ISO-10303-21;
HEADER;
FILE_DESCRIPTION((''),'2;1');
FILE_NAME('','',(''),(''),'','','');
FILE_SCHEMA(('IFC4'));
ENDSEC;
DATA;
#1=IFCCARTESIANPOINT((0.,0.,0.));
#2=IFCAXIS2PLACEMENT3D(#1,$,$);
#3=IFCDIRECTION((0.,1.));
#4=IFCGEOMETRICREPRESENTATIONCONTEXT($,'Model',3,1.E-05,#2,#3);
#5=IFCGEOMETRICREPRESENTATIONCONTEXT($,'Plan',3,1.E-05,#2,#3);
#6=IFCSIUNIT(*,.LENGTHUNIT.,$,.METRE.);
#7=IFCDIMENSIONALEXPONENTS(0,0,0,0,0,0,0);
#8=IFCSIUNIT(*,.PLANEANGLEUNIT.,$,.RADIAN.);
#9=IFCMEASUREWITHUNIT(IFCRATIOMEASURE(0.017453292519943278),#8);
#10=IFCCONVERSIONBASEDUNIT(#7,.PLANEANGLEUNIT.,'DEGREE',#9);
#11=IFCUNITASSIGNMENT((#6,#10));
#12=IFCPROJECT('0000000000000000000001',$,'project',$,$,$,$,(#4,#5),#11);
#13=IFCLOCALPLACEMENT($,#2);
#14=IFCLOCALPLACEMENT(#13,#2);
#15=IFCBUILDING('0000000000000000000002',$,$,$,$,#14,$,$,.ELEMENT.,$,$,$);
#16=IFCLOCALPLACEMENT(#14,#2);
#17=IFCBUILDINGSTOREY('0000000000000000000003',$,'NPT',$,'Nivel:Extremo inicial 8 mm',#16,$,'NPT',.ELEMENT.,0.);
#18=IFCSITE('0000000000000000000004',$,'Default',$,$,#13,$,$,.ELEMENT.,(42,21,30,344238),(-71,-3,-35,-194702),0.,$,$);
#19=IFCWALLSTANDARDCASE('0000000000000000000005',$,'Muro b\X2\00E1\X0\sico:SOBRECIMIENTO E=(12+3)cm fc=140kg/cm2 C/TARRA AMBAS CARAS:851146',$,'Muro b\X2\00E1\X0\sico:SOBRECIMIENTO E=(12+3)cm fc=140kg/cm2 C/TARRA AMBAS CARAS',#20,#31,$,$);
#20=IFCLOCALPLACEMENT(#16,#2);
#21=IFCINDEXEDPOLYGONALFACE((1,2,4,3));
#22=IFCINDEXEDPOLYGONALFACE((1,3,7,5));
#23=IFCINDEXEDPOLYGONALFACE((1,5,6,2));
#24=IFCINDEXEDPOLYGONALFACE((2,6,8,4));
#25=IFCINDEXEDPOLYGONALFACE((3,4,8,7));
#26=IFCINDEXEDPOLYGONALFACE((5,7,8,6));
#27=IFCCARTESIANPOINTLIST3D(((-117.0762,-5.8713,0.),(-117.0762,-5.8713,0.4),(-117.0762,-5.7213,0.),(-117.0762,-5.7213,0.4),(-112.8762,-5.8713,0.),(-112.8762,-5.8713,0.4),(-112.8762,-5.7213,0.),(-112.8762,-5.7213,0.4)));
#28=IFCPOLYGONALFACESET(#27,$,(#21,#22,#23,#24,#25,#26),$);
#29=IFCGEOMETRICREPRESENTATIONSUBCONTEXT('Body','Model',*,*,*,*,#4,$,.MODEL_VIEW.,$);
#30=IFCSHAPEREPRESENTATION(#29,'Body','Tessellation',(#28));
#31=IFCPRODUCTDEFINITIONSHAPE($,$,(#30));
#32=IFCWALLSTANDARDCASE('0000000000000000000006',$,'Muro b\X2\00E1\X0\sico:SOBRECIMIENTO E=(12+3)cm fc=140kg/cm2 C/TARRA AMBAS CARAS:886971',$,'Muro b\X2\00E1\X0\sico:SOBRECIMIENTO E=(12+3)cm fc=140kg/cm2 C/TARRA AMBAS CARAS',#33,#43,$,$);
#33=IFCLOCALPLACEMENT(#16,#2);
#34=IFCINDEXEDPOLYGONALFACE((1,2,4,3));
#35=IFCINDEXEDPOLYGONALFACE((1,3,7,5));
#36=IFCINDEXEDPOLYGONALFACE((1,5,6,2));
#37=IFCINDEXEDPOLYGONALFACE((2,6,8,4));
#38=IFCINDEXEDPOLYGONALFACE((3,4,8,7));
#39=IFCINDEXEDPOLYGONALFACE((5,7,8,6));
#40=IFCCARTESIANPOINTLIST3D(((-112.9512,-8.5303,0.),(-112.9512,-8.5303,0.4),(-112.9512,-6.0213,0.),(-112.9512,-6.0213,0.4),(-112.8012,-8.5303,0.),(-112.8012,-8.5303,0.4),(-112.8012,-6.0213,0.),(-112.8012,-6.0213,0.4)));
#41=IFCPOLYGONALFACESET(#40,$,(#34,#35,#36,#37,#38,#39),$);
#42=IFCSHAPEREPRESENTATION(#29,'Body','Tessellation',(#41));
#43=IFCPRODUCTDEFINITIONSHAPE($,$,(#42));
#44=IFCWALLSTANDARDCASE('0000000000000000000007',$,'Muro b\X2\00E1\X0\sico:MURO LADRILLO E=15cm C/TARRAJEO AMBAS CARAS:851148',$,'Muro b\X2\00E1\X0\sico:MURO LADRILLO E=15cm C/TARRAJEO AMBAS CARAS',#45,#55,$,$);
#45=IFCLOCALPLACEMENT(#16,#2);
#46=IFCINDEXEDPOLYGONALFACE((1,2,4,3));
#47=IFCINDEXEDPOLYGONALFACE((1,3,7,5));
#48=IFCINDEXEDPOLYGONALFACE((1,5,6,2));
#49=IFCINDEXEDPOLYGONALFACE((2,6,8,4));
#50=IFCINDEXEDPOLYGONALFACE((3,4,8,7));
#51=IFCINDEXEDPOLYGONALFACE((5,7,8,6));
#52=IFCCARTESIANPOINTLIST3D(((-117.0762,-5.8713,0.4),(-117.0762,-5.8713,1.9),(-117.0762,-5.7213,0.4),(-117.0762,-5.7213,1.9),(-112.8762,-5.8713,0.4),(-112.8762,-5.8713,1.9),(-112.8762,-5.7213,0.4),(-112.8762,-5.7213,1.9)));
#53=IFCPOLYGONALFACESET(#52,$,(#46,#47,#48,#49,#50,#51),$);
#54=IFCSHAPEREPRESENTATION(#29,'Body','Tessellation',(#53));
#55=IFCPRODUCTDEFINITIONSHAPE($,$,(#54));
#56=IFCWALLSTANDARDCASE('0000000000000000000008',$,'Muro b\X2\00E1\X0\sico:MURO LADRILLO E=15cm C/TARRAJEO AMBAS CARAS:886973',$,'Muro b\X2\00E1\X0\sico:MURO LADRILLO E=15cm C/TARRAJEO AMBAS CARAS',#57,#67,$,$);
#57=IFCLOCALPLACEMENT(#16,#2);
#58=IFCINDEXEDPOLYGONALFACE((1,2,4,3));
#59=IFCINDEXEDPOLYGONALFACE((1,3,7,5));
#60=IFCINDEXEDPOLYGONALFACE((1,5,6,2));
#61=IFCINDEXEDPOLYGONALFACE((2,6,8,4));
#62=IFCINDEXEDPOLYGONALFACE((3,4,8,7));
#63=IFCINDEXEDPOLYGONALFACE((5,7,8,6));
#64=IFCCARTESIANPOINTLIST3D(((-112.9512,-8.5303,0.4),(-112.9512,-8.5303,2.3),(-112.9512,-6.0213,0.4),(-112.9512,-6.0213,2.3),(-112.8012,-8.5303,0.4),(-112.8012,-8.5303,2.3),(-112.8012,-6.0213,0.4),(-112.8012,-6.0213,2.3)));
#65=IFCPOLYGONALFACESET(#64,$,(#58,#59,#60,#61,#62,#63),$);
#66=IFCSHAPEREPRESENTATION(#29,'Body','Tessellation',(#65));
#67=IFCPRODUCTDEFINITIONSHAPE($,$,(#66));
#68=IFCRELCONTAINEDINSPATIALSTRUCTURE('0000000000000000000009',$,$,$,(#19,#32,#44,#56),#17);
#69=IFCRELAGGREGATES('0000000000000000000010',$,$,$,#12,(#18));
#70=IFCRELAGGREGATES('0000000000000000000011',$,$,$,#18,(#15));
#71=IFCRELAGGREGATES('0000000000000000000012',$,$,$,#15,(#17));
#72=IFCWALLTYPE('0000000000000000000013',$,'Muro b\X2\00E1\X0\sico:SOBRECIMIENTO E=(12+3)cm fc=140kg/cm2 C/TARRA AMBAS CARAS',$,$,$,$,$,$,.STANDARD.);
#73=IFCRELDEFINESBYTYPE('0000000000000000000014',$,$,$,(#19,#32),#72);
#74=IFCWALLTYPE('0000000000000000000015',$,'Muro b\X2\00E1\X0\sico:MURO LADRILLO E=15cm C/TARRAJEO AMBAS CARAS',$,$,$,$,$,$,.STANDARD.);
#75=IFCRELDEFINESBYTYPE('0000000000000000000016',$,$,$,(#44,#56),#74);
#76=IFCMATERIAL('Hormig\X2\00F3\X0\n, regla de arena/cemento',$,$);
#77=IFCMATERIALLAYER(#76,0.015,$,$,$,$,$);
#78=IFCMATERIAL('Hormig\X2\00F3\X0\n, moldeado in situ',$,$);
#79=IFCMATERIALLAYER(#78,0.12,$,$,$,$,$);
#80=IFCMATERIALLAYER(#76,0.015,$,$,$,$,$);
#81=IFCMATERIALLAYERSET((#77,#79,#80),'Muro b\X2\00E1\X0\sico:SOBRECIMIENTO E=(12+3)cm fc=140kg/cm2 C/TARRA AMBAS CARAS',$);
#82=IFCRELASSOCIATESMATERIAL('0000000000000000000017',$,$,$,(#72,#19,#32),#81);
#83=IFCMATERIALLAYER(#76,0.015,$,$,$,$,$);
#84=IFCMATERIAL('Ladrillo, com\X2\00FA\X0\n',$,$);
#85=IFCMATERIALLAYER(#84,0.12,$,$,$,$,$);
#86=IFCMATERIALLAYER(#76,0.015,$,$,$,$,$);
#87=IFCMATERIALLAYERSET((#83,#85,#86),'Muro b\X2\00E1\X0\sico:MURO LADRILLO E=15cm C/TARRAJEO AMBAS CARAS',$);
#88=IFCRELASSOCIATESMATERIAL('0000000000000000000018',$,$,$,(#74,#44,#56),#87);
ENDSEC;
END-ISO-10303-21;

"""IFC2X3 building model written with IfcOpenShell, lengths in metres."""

from ifc_helpers import new_model, entity, si_unit, converted_unit, direction, frame, frame_2d, origin, place, context, subcontext, project, spatial, rectangle, extrude, material, layer, layer_set, layer_usage, type_object, element, save


model = new_model("IFC2X3")

# Units and contexts
model_context = context("Model", 3, precision=1e-05, world=origin(), true_north=direction((0.0, 1.0)))
plan_context = context("Plan", 3, precision=1e-05, world=origin(), true_north=direction((0.0, 1.0)))
body_context = subcontext(model_context, "Body", "Model", "MODEL_VIEW")
ifc_project = project(units=[si_unit("LENGTHUNIT", "METRE"), converted_unit("PLANEANGLEUNIT", "DEGREE", entity("IfcRatioMeasure", 0.017453292519943278), si_unit("PLANEANGLEUNIT", "RADIAN"), dimensions=[0, 0, 0, 0, 0, 0, 0])], contexts=[model_context, plan_context])

# Site, building, storey
site_placement = place(None, origin())
site = spatial("IfcSite", under=ifc_project, at=site_placement, Name="Default", CompositionType="ELEMENT", RefLatitude=(42, 21, 30, 344238), RefLongitude=(-71, -3, -35, -194702), RefElevation=0.0)
building_placement = place(site_placement, origin())
building = spatial("IfcBuilding", under=site, at=building_placement, CompositionType="ELEMENT")
storey_placement = place(building_placement, origin())
storey = spatial("IfcBuildingStorey", under=building, at=storey_placement, Name="NPT", ObjectType="Nivel:Extremo inicial 8 mm", LongName="NPT", CompositionType="ELEMENT", Elevation=0.0)

# Shared definitions
ifc_material_1 = material(Name="Hormigón, moldeado in situ")

# Walls
ifc_material_2 = material(Name="Hormigón, regla de arena/cemento")
ifc_layer_1 = layer(ifc_material_2, 0.015)
ifc_layer_2 = layer(ifc_material_1, 0.12)
ifc_layer_3 = layer(ifc_material_2, 0.015)
ifc_layer_set_1 = layer_set([ifc_layer_1, ifc_layer_2, ifc_layer_3], Name="Muro básico:SOBRECIMIENTO E=(12+3)cm fc=140kg/cm2 C/TARRA AMBAS CARAS")
ifc_layer_usage_1 = layer_usage(ifc_layer_set_1, "AXIS2", "POSITIVE", -0.075)
wall_type_1 = type_object("IfcWallType", Name="Muro básico:SOBRECIMIENTO E=(12+3)cm fc=140kg/cm2 C/TARRA AMBAS CARAS", PredefinedType="STANDARD", material=ifc_layer_set_1)
wall_1_placement = place(storey_placement, frame((-112.8762, -5.7963, 0.0), z_axis=(0.0, 0.0, 1.0), x_axis=(-1.0, 0.0, 0.0)))
element("IfcWallStandardCase", 1, at=wall_1_placement, inside=storey, type_object=wall_type_1, material=ifc_layer_usage_1, Name="Muro básico:SOBRECIMIENTO E=(12+3)cm fc=140kg/cm2 C/TARRA AMBAS CARAS:851146", ObjectType="Muro básico:SOBRECIMIENTO E=(12+3)cm fc=140kg/cm2 C/TARRA AMBAS CARAS", context=body_context, shape_type="SweptSolid", body=[
    extrude(rectangle(XDim=4.2, YDim=0.15, at=frame_2d((2.1, 0.0), x_axis=(-1.0, 0.0))), origin(), (0.0, 0.0, 1.0), 0.4),
])
ifc_layer_usage_2 = layer_usage(ifc_layer_set_1, "AXIS2", "POSITIVE", -0.075)
wall_2_placement = place(storey_placement, frame((-112.8762, -6.0213, 0.0), z_axis=(0.0, 0.0, 1.0), x_axis=(0.0, -1.0, 0.0)))
element("IfcWallStandardCase", 2, at=wall_2_placement, inside=storey, type_object=wall_type_1, material=ifc_layer_usage_2, Name="Muro básico:SOBRECIMIENTO E=(12+3)cm fc=140kg/cm2 C/TARRA AMBAS CARAS:886971", ObjectType="Muro básico:SOBRECIMIENTO E=(12+3)cm fc=140kg/cm2 C/TARRA AMBAS CARAS", context=body_context, shape_type="SweptSolid", body=[
    extrude(rectangle(XDim=2.5091, YDim=0.15, at=frame_2d((1.2545, 0.0), x_axis=(-1.0, 0.0))), origin(), (0.0, 0.0, 1.0), 0.4),
])
ifc_layer_4 = layer(ifc_material_2, 0.015)
ifc_material_3 = material(Name="Ladrillo, común")
ifc_layer_5 = layer(ifc_material_3, 0.12)
ifc_layer_6 = layer(ifc_material_2, 0.015)
ifc_layer_set_2 = layer_set([ifc_layer_4, ifc_layer_5, ifc_layer_6], Name="Muro básico:MURO LADRILLO E=15cm C/TARRAJEO AMBAS CARAS")
ifc_layer_usage_3 = layer_usage(ifc_layer_set_2, "AXIS2", "POSITIVE", -0.075)
wall_type_2 = type_object("IfcWallType", Name="Muro básico:MURO LADRILLO E=15cm C/TARRAJEO AMBAS CARAS", PredefinedType="STANDARD", material=ifc_layer_set_2)
wall_3_placement = place(storey_placement, frame((-112.8762, -5.7963, 0.4), z_axis=(0.0, 0.0, 1.0), x_axis=(-1.0, 0.0, 0.0)))
element("IfcWallStandardCase", 3, at=wall_3_placement, inside=storey, type_object=wall_type_2, material=ifc_layer_usage_3, Name="Muro básico:MURO LADRILLO E=15cm C/TARRAJEO AMBAS CARAS:851148", ObjectType="Muro básico:MURO LADRILLO E=15cm C/TARRAJEO AMBAS CARAS", context=body_context, shape_type="SweptSolid", body=[
    extrude(rectangle(XDim=4.2, YDim=0.15, at=frame_2d((2.1, 0.0), x_axis=(-1.0, 0.0))), origin(), (0.0, 0.0, 1.0), 1.5),
])
ifc_layer_usage_4 = layer_usage(ifc_layer_set_2, "AXIS2", "POSITIVE", -0.075)
wall_4_placement = place(storey_placement, frame((-112.8762, -6.0213, 0.4), z_axis=(0.0, 0.0, 1.0), x_axis=(0.0, -1.0, 0.0)))
element("IfcWallStandardCase", 4, at=wall_4_placement, inside=storey, type_object=wall_type_2, material=ifc_layer_usage_4, Name="Muro básico:MURO LADRILLO E=15cm C/TARRAJEO AMBAS CARAS:886973", ObjectType="Muro básico:MURO LADRILLO E=15cm C/TARRAJEO AMBAS CARAS", context=body_context, shape_type="SweptSolid", body=[
    extrude(rectangle(XDim=2.5091, YDim=0.15, at=frame_2d((1.2545, 0.0), x_axis=(-1.0, 0.0))), origin(), (0.0, 0.0, 1.0), 1.9),
])

save(model, "model.ifc")
